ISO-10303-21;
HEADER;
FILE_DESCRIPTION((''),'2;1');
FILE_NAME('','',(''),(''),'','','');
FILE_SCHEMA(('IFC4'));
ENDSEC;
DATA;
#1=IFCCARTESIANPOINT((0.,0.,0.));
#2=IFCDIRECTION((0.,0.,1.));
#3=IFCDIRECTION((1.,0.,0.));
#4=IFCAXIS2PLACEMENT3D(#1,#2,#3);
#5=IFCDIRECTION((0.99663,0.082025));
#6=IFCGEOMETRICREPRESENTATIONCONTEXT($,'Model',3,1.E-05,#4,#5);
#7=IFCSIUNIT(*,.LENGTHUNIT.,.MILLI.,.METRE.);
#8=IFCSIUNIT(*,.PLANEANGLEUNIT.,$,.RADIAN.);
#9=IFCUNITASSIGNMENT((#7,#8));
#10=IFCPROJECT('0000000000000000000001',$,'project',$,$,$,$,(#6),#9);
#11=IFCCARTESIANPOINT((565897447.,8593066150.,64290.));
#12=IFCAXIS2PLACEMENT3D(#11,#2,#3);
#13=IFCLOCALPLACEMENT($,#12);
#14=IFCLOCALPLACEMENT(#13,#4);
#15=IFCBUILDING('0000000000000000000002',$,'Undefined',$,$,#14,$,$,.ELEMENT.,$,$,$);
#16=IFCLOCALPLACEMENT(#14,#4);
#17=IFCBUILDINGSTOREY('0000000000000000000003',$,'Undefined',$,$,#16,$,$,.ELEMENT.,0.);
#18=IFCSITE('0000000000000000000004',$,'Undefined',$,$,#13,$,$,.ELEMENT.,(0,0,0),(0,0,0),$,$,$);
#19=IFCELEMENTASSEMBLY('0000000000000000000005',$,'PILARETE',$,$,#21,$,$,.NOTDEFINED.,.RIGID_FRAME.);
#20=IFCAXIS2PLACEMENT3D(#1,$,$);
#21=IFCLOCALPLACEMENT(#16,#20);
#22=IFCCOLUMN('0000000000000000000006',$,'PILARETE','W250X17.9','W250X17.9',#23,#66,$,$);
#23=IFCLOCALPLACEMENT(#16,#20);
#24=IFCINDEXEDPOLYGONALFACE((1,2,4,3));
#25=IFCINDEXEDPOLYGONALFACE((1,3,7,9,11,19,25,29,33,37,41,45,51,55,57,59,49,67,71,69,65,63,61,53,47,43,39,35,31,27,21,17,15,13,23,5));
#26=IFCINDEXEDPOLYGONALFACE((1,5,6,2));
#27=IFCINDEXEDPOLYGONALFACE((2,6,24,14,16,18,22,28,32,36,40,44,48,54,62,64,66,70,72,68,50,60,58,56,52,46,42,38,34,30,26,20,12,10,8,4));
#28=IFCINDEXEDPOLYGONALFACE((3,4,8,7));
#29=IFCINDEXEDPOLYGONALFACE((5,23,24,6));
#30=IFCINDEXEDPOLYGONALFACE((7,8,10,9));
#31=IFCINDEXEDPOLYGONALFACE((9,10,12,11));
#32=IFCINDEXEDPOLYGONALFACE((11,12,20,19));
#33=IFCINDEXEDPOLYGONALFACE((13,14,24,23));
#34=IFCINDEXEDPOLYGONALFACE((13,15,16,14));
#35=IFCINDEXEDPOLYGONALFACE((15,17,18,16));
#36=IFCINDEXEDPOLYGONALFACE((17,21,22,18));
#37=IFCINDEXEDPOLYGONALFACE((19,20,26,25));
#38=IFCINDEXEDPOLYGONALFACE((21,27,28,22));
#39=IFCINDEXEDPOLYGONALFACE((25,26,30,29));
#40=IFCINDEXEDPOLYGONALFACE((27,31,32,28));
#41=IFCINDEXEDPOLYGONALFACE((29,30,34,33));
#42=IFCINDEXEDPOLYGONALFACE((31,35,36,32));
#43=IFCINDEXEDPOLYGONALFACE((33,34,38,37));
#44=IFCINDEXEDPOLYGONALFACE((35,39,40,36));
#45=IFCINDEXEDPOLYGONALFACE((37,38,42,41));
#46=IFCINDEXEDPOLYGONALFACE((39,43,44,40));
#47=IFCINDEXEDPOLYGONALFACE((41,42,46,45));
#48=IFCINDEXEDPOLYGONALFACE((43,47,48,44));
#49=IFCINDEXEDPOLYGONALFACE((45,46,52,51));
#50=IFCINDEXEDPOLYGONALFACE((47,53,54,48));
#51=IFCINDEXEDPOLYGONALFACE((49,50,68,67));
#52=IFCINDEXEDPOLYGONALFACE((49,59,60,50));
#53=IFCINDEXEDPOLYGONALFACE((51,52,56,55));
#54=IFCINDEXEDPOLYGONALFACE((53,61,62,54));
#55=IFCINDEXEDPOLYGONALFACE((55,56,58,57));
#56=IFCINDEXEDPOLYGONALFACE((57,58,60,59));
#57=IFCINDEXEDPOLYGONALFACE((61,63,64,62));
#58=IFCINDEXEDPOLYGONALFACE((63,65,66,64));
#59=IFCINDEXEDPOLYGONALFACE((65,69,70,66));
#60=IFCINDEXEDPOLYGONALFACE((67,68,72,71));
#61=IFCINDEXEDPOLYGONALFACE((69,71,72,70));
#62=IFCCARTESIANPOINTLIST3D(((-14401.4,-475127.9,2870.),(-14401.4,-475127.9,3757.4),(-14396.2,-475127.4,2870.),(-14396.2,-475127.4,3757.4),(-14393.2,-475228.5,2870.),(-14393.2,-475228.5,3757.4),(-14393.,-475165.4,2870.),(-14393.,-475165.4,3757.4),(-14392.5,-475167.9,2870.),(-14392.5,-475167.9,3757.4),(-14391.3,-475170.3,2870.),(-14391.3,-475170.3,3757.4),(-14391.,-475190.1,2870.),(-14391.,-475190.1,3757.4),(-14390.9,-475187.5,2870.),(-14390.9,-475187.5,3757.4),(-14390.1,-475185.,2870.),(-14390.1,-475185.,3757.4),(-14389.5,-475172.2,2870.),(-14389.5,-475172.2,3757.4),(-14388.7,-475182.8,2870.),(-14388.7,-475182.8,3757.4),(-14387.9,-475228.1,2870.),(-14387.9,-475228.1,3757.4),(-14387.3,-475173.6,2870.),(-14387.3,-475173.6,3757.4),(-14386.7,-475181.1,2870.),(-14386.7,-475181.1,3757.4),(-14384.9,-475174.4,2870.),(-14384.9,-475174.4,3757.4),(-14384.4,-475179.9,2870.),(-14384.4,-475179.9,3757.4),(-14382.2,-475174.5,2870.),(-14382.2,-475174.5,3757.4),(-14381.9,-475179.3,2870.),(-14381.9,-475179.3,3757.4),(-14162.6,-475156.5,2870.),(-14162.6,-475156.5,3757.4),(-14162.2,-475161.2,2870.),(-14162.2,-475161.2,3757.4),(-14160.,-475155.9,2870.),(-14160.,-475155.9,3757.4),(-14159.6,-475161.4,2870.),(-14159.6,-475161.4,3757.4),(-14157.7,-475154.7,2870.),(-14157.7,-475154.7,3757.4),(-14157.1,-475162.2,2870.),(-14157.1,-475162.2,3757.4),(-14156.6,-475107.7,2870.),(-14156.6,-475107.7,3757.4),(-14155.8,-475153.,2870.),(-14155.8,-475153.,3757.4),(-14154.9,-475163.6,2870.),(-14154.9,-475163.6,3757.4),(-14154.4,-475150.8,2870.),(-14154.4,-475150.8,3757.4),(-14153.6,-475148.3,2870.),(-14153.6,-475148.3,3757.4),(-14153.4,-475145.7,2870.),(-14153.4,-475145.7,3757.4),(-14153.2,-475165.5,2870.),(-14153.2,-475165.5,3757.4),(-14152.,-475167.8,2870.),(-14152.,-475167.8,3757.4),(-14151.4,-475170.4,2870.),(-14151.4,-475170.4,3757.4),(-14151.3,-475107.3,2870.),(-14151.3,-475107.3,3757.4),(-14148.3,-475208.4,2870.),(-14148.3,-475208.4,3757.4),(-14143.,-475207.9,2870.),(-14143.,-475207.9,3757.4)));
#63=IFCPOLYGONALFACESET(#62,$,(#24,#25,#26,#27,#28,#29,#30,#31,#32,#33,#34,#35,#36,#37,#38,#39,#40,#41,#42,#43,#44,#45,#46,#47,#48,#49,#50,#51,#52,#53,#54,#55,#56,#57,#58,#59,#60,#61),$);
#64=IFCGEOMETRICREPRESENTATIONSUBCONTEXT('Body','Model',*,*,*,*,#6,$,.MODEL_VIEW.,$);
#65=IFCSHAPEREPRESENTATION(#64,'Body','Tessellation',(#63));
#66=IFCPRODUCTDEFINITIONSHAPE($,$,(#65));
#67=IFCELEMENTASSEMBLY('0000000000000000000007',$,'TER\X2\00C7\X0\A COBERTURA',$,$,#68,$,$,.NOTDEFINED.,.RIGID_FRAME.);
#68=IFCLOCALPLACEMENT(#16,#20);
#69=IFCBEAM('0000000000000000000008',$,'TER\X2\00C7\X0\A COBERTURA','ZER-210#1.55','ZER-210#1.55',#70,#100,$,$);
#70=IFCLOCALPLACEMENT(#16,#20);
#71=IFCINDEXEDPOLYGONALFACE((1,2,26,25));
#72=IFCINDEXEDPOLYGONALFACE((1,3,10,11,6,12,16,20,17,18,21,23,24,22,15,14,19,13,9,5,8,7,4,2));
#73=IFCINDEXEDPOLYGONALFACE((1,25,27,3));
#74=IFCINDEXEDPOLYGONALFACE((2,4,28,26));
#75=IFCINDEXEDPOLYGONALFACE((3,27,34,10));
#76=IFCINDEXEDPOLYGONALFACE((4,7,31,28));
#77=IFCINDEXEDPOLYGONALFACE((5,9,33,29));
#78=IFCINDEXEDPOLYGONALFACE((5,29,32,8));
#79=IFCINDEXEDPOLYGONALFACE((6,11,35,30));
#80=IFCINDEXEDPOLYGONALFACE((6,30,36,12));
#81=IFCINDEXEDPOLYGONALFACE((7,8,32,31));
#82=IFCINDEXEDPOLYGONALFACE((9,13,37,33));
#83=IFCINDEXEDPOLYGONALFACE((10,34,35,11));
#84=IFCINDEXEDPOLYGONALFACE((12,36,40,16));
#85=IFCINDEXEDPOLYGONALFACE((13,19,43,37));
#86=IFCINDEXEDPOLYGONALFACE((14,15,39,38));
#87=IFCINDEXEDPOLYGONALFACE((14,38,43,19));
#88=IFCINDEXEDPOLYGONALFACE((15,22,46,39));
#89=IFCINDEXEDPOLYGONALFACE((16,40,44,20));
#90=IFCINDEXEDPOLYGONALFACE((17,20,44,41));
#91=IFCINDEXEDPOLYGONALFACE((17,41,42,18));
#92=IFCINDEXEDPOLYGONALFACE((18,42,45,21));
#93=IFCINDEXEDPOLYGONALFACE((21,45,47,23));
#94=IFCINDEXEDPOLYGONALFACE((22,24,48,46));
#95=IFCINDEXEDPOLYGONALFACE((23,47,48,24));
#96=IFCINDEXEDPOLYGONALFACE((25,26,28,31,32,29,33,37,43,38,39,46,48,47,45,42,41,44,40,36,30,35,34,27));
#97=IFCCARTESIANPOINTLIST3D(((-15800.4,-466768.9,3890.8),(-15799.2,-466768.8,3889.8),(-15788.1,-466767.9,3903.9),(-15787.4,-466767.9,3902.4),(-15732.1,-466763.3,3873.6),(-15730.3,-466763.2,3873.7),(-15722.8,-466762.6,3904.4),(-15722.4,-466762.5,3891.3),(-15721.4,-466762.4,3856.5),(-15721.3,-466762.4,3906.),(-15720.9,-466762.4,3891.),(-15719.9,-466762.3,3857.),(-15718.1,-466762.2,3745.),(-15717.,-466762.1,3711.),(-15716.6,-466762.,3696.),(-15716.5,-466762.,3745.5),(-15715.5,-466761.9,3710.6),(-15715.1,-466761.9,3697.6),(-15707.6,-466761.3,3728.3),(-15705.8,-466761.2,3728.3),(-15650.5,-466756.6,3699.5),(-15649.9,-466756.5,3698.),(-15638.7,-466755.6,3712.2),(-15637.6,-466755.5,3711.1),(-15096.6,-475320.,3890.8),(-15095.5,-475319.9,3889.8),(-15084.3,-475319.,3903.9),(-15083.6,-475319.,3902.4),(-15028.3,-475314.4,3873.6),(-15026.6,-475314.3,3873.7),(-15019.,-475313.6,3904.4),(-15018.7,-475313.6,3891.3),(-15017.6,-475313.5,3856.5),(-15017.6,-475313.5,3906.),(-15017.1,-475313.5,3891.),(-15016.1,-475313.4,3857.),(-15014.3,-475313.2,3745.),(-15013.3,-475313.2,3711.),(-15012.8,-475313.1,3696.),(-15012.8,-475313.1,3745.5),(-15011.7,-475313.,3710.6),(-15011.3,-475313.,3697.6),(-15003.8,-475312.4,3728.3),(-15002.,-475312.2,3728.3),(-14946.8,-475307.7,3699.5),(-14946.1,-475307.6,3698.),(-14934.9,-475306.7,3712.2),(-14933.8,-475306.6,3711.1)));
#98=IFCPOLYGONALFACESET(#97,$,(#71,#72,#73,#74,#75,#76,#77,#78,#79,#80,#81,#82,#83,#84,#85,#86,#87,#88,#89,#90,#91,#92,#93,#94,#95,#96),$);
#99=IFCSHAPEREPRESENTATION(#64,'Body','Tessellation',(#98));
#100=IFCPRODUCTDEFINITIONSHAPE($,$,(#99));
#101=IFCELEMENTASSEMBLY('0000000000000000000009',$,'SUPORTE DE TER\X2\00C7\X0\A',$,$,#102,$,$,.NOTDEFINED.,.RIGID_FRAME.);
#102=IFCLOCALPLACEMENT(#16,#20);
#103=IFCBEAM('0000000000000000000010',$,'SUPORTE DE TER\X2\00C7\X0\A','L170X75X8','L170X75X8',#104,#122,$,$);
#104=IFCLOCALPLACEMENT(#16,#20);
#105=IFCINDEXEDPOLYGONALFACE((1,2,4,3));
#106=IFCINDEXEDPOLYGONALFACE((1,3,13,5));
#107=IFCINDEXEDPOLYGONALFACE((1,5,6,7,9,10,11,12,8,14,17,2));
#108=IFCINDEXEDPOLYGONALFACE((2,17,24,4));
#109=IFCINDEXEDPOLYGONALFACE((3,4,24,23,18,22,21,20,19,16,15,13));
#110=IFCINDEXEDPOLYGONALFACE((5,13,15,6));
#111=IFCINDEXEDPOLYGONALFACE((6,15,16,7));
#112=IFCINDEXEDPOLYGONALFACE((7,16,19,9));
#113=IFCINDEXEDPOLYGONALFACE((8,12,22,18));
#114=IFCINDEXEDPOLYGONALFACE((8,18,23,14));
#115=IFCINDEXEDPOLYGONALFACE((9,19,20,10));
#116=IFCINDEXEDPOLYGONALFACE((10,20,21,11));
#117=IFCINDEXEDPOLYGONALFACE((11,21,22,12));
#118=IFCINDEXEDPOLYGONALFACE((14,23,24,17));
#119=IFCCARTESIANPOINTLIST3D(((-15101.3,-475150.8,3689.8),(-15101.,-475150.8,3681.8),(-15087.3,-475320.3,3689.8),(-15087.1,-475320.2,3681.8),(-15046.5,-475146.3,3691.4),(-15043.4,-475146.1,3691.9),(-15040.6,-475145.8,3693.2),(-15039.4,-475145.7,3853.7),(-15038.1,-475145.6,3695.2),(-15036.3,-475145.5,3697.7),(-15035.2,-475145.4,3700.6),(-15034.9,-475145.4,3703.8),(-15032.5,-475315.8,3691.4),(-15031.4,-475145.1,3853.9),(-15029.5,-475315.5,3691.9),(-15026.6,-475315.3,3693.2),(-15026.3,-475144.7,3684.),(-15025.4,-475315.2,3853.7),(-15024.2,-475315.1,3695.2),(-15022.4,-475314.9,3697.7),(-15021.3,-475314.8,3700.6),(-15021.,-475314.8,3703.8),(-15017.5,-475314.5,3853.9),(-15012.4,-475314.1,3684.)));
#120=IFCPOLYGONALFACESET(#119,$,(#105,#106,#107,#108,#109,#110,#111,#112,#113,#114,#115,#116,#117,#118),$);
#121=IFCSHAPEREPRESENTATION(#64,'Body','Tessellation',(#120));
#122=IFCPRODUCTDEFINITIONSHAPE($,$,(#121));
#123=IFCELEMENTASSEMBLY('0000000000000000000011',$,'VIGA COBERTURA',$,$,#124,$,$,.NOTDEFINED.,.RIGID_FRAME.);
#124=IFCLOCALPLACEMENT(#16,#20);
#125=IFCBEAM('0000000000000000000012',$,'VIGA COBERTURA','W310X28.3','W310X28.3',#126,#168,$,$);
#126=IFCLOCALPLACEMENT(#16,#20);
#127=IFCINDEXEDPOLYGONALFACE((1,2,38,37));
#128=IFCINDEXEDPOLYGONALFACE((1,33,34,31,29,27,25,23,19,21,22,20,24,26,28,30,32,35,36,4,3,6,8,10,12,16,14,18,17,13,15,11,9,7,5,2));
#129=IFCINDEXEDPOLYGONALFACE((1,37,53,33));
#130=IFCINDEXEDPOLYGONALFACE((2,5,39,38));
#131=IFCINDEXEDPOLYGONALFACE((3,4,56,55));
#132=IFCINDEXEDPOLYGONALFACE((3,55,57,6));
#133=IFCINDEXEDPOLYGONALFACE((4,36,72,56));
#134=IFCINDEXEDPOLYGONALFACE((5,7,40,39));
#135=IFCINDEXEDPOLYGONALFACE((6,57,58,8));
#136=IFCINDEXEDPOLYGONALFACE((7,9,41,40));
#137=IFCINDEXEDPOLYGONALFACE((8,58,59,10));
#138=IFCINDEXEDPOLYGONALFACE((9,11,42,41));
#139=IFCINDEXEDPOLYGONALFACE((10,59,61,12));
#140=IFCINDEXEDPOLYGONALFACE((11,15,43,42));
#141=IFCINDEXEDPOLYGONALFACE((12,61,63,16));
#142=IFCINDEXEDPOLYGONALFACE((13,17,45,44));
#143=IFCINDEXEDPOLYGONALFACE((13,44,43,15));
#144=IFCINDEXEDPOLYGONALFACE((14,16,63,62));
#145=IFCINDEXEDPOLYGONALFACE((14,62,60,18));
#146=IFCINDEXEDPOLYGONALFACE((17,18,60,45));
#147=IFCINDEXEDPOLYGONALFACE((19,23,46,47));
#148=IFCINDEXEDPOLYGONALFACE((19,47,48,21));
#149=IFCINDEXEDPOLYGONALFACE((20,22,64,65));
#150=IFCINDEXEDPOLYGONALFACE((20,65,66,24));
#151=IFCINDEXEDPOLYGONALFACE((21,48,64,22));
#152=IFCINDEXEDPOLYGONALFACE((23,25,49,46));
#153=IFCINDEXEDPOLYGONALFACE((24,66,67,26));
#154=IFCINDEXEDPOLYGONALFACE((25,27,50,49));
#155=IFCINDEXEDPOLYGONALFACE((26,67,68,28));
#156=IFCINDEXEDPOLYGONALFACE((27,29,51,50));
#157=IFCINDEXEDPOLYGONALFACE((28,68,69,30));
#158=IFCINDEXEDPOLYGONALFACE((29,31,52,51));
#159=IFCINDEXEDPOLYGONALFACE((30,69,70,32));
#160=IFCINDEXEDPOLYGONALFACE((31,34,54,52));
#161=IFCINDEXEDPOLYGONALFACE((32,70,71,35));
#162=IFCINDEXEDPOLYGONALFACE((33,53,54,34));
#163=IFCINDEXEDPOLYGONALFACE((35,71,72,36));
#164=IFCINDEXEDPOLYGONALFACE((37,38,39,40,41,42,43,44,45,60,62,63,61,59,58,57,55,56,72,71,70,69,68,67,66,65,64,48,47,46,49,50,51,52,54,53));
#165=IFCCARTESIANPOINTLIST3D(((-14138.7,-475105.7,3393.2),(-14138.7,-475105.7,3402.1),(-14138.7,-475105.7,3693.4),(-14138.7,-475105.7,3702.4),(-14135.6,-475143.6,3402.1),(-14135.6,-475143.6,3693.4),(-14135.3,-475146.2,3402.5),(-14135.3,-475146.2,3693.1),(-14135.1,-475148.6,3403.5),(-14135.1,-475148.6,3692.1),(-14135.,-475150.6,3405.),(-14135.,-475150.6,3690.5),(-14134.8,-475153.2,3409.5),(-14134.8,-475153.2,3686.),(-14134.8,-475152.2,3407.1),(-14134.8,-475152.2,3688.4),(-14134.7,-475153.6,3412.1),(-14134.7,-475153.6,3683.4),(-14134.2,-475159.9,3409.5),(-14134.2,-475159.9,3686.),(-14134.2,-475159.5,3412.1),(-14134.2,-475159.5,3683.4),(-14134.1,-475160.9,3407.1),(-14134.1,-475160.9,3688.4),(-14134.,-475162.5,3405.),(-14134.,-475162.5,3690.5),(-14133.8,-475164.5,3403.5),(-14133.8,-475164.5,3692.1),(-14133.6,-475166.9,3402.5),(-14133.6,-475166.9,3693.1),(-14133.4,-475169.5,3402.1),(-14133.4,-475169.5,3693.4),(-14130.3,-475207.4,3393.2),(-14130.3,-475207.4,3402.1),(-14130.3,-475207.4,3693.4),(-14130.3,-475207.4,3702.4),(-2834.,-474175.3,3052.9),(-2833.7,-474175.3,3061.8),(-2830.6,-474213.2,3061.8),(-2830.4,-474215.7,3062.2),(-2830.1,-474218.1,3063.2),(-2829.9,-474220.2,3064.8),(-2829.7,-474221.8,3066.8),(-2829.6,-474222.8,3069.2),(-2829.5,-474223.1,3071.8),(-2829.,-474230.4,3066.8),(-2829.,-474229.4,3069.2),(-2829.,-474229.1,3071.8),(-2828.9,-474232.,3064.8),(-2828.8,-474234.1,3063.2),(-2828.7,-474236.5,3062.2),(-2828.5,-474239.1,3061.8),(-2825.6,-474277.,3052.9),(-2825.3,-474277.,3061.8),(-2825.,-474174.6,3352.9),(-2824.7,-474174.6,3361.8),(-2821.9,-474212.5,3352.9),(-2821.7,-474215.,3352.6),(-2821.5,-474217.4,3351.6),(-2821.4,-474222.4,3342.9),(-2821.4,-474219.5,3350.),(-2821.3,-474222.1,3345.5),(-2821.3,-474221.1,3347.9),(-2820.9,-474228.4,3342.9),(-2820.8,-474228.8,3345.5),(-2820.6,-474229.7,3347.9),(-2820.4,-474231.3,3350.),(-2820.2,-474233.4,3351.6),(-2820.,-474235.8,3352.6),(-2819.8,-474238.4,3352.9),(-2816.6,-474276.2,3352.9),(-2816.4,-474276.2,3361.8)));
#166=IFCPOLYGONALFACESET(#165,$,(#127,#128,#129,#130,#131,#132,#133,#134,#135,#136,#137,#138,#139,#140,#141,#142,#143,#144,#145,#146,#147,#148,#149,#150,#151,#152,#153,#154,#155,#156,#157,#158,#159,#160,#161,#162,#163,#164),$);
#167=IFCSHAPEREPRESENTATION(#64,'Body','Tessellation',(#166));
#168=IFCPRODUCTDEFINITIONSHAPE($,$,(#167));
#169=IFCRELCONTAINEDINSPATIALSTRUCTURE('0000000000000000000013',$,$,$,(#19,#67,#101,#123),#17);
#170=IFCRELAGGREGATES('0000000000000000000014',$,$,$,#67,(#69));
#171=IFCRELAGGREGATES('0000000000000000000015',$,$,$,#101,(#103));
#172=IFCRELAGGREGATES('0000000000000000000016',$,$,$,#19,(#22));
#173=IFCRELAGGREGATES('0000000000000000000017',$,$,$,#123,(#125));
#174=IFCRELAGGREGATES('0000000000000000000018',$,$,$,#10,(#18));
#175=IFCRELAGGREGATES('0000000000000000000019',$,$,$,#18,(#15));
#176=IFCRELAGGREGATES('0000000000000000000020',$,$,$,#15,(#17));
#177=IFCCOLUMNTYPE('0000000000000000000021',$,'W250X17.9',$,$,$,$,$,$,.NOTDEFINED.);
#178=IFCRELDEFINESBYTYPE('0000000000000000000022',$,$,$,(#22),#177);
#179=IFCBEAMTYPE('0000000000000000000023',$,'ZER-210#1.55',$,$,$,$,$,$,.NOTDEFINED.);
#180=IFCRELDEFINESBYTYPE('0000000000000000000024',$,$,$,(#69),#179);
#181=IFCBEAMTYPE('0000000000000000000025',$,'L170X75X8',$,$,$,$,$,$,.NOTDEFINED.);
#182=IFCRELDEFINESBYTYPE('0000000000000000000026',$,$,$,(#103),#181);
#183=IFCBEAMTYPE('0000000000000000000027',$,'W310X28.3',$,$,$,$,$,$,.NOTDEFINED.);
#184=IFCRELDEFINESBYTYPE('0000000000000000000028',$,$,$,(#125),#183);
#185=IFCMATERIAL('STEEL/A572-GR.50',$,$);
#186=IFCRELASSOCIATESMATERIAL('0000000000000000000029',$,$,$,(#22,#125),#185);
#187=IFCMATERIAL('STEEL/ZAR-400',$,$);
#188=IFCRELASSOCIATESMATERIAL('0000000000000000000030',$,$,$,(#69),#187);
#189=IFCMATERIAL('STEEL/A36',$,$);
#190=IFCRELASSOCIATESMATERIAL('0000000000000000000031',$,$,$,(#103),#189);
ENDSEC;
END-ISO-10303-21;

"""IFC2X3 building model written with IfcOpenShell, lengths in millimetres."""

from ifc_helpers import new_model, si_unit, direction, frame, origin_with_axes, origin_2d_with_axis, place, context, subcontext, project, spatial, polyline, i_section, l_section, outline, extrude, clip, halfspace, material, type_object, element, aggregate, save


model = new_model("IFC2X3")

# Units and contexts
model_context = context("Model", 3, precision=1e-05, world=origin_with_axes(), true_north=direction((0.99663, 0.082025)))
body_context = subcontext(model_context, "Body", "Model", "MODEL_VIEW")
ifc_project = project(units=[si_unit("LENGTHUNIT", "METRE", prefix="MILLI"), si_unit("PLANEANGLEUNIT", "RADIAN")], contexts=[model_context])

# Site, building, storey
site_placement = place(None, frame((565897447.0, 8593066150.0, 64290.0), z_axis=(0.0, 0.0, 1.0), x_axis=(1.0, 0.0, 0.0)))
site = spatial("IfcSite", under=ifc_project, at=site_placement, Name="Undefined", CompositionType="ELEMENT", RefLatitude=(0, 0, 0), RefLongitude=(0, 0, 0))
building_placement = place(site_placement, origin_with_axes())
building = spatial("IfcBuilding", under=site, at=building_placement, Name="Undefined", CompositionType="ELEMENT")
storey_placement = place(building_placement, origin_with_axes())
storey = spatial("IfcBuildingStorey", under=building, at=storey_placement, Name="Undefined", CompositionType="ELEMENT", Elevation=0.0)

# Element assembly, column
assembly_1_placement = place(storey_placement, origin_with_axes())
assembly_1 = element("IfcElementAssembly", 1, at=assembly_1_placement, inside=storey, Name="PILARETE", AssemblyPlace="NOTDEFINED", PredefinedType="RIGID_FRAME")
ifc_material_1 = material(Name="STEEL/A572-GR.50")
column_type = type_object("IfcColumnType", Name="W250X17.9", PredefinedType="NOTDEFINED")
column_placement = place(assembly_1_placement, frame((-14272.2, -475167.9, 2870.0), z_axis=(0.0, 0.0, 1.0), x_axis=(-0.99663, -0.082025, 0.0)))
column = element("IfcColumn", 2, at=column_placement, type_object=column_type, material=ifc_material_1, Name="PILARETE", Description="W250X17.9", ObjectType="W250X17.9", context=body_context, shape_type="SweptSolid", body=[
    extrude(i_section(OverallWidth=101.0, OverallDepth=251.0, WebThickness=4.8, FlangeThickness=5.3, FilletRadius=10.0, at=origin_2d_with_axis()), frame((0.0, 0.0, 887.4), z_axis=(0.0, 0.0, -1.0), x_axis=(0.0, 1.0, 0.0)), (0.0, 0.0, 1.0), 887.4),
])

# Element assemblies, beams
assembly_2_placement = place(storey_placement, origin_with_axes())
assembly_2 = element("IfcElementAssembly", 3, at=assembly_2_placement, inside=storey, Name="TERÇA COBERTURA", AssemblyPlace="NOTDEFINED", PredefinedType="RIGID_FRAME")
ifc_material_2 = material(Name="STEEL/ZAR-400")
beam_type_1 = type_object("IfcBeamType", Name="ZER-210#1.55", PredefinedType="NOTDEFINED")
beam_1_placement = place(assembly_2_placement, frame((-15015.2, -475313.3, 3801.0), z_axis=(-0.029885, -0.00246, 0.99955), x_axis=(-0.082025, 0.99663, 0.0)))
beam_1 = element("IfcBeam", 4, at=beam_1_placement, type_object=beam_type_1, material=ifc_material_2, Name="TERÇA COBERTURA", Description="ZER-210#1.55", ObjectType="ZER-210#1.55", context=body_context, shape_type="SweptSolid", body=[
    extrude(outline(polyline([(-65.6, 103.4), (-77.9, 91.2), (-79.0, 92.3), (-66.2, 105.0), (0.8, 105.0), (0.8, 90.0), (-9.2, 73.0), (0.8, 56.0), (0.8, -55.6), (11.0, -73.0), (0.8, -90.4), (0.8, -103.5), (65.6, -103.4), (77.9, -91.2), (79.0, -92.3), (66.2, -105.0), (-0.8, -105.0), (-0.8, -90.0), (9.2, -73.0), (-0.8, -56.0), (-0.8, 55.6), (-11.0, 73.0), (-0.8, 90.4), (-0.8, 103.5), (-65.6, 103.4)])), frame((8580.0, 0.0, 0.0), z_axis=(-1.0, 0.0, 0.0), x_axis=(0.0, -1.0, 0.0)), (0.0, 0.0, 1.0), 8580.0),
])
aggregate(assembly_2, [beam_1])
assembly_3_placement = place(storey_placement, origin_with_axes())
assembly_3 = element("IfcElementAssembly", 5, at=assembly_3_placement, inside=storey, Name="SUPORTE DE TERÇA", AssemblyPlace="NOTDEFINED", PredefinedType="RIGID_FRAME")
ifc_material_3 = material(Name="STEEL/A36")
beam_type_2 = type_object("IfcBeamType", Name="L170X75X8", PredefinedType="NOTDEFINED")
beam_2_placement = place(assembly_3_placement, frame((-15066.2, -475148.0, 3767.8), z_axis=(-0.029885, -0.00246, 0.99955), x_axis=(0.082025, -0.99663, 0.0)))
beam_2 = element("IfcBeam", 6, at=beam_2_placement, type_object=beam_type_2, material=ifc_material_3, Name="SUPORTE DE TERÇA", Description="L170X75X8", ObjectType="L170X75X8", context=body_context, shape_type="SweptSolid", body=[
    extrude(l_section(Depth=170.0, Width=75.0, Thickness=8.0, FilletRadius=12.0, at=origin_2d_with_axis()), frame((170.0, 0.0, 0.0), z_axis=(-1.0, 0.0, 0.0), x_axis=(0.0, -1.0, 0.0)), (0.0, 0.0, 1.0), 170.0),
])
aggregate(assembly_3, [beam_2])
assembly_4_placement = place(storey_placement, origin_with_axes())
assembly_4 = element("IfcElementAssembly", 7, at=assembly_4_placement, inside=storey, Name="VIGA COBERTURA", AssemblyPlace="NOTDEFINED", PredefinedType="RIGID_FRAME")
beam_type_3 = type_object("IfcBeamType", Name="W310X28.3", PredefinedType="NOTDEFINED")
beam_3_placement = place(assembly_4_placement, frame((-14151.8, -475158.0, 3548.3), z_axis=(-0.029885, -0.00246, -0.99955), x_axis=(0.996182, 0.081989, -0.029987)))
beam_3 = element("IfcBeam", 8, at=beam_3_placement, type_object=beam_type_3, material=ifc_material_1, Name="VIGA COBERTURA", Description="W310X28.3", ObjectType="W310X28.3", context=body_context, shape_type="Clipping", body=[
    clip(extrude(i_section(OverallWidth=102.0, OverallDepth=309.0, WebThickness=6.0, FlangeThickness=8.9, FilletRadius=10.0, at=origin_2d_with_axis()), frame((11370.0, 0.0, 0.0), z_axis=(-1.0, 0.0, 0.0), x_axis=(0.0, -1.0, 0.0)), (0.0, 0.0, 1.0), 11370.0), halfspace(frame((12.7, 51.0, -154.5), z_axis=(-0.99955, 0.0, 0.029987), x_axis=(0.029987, 0.0, 0.99955)), False)),
])

aggregate(assembly_1, [column])
aggregate(assembly_4, [beam_3])

save(model, "model.ifc")
